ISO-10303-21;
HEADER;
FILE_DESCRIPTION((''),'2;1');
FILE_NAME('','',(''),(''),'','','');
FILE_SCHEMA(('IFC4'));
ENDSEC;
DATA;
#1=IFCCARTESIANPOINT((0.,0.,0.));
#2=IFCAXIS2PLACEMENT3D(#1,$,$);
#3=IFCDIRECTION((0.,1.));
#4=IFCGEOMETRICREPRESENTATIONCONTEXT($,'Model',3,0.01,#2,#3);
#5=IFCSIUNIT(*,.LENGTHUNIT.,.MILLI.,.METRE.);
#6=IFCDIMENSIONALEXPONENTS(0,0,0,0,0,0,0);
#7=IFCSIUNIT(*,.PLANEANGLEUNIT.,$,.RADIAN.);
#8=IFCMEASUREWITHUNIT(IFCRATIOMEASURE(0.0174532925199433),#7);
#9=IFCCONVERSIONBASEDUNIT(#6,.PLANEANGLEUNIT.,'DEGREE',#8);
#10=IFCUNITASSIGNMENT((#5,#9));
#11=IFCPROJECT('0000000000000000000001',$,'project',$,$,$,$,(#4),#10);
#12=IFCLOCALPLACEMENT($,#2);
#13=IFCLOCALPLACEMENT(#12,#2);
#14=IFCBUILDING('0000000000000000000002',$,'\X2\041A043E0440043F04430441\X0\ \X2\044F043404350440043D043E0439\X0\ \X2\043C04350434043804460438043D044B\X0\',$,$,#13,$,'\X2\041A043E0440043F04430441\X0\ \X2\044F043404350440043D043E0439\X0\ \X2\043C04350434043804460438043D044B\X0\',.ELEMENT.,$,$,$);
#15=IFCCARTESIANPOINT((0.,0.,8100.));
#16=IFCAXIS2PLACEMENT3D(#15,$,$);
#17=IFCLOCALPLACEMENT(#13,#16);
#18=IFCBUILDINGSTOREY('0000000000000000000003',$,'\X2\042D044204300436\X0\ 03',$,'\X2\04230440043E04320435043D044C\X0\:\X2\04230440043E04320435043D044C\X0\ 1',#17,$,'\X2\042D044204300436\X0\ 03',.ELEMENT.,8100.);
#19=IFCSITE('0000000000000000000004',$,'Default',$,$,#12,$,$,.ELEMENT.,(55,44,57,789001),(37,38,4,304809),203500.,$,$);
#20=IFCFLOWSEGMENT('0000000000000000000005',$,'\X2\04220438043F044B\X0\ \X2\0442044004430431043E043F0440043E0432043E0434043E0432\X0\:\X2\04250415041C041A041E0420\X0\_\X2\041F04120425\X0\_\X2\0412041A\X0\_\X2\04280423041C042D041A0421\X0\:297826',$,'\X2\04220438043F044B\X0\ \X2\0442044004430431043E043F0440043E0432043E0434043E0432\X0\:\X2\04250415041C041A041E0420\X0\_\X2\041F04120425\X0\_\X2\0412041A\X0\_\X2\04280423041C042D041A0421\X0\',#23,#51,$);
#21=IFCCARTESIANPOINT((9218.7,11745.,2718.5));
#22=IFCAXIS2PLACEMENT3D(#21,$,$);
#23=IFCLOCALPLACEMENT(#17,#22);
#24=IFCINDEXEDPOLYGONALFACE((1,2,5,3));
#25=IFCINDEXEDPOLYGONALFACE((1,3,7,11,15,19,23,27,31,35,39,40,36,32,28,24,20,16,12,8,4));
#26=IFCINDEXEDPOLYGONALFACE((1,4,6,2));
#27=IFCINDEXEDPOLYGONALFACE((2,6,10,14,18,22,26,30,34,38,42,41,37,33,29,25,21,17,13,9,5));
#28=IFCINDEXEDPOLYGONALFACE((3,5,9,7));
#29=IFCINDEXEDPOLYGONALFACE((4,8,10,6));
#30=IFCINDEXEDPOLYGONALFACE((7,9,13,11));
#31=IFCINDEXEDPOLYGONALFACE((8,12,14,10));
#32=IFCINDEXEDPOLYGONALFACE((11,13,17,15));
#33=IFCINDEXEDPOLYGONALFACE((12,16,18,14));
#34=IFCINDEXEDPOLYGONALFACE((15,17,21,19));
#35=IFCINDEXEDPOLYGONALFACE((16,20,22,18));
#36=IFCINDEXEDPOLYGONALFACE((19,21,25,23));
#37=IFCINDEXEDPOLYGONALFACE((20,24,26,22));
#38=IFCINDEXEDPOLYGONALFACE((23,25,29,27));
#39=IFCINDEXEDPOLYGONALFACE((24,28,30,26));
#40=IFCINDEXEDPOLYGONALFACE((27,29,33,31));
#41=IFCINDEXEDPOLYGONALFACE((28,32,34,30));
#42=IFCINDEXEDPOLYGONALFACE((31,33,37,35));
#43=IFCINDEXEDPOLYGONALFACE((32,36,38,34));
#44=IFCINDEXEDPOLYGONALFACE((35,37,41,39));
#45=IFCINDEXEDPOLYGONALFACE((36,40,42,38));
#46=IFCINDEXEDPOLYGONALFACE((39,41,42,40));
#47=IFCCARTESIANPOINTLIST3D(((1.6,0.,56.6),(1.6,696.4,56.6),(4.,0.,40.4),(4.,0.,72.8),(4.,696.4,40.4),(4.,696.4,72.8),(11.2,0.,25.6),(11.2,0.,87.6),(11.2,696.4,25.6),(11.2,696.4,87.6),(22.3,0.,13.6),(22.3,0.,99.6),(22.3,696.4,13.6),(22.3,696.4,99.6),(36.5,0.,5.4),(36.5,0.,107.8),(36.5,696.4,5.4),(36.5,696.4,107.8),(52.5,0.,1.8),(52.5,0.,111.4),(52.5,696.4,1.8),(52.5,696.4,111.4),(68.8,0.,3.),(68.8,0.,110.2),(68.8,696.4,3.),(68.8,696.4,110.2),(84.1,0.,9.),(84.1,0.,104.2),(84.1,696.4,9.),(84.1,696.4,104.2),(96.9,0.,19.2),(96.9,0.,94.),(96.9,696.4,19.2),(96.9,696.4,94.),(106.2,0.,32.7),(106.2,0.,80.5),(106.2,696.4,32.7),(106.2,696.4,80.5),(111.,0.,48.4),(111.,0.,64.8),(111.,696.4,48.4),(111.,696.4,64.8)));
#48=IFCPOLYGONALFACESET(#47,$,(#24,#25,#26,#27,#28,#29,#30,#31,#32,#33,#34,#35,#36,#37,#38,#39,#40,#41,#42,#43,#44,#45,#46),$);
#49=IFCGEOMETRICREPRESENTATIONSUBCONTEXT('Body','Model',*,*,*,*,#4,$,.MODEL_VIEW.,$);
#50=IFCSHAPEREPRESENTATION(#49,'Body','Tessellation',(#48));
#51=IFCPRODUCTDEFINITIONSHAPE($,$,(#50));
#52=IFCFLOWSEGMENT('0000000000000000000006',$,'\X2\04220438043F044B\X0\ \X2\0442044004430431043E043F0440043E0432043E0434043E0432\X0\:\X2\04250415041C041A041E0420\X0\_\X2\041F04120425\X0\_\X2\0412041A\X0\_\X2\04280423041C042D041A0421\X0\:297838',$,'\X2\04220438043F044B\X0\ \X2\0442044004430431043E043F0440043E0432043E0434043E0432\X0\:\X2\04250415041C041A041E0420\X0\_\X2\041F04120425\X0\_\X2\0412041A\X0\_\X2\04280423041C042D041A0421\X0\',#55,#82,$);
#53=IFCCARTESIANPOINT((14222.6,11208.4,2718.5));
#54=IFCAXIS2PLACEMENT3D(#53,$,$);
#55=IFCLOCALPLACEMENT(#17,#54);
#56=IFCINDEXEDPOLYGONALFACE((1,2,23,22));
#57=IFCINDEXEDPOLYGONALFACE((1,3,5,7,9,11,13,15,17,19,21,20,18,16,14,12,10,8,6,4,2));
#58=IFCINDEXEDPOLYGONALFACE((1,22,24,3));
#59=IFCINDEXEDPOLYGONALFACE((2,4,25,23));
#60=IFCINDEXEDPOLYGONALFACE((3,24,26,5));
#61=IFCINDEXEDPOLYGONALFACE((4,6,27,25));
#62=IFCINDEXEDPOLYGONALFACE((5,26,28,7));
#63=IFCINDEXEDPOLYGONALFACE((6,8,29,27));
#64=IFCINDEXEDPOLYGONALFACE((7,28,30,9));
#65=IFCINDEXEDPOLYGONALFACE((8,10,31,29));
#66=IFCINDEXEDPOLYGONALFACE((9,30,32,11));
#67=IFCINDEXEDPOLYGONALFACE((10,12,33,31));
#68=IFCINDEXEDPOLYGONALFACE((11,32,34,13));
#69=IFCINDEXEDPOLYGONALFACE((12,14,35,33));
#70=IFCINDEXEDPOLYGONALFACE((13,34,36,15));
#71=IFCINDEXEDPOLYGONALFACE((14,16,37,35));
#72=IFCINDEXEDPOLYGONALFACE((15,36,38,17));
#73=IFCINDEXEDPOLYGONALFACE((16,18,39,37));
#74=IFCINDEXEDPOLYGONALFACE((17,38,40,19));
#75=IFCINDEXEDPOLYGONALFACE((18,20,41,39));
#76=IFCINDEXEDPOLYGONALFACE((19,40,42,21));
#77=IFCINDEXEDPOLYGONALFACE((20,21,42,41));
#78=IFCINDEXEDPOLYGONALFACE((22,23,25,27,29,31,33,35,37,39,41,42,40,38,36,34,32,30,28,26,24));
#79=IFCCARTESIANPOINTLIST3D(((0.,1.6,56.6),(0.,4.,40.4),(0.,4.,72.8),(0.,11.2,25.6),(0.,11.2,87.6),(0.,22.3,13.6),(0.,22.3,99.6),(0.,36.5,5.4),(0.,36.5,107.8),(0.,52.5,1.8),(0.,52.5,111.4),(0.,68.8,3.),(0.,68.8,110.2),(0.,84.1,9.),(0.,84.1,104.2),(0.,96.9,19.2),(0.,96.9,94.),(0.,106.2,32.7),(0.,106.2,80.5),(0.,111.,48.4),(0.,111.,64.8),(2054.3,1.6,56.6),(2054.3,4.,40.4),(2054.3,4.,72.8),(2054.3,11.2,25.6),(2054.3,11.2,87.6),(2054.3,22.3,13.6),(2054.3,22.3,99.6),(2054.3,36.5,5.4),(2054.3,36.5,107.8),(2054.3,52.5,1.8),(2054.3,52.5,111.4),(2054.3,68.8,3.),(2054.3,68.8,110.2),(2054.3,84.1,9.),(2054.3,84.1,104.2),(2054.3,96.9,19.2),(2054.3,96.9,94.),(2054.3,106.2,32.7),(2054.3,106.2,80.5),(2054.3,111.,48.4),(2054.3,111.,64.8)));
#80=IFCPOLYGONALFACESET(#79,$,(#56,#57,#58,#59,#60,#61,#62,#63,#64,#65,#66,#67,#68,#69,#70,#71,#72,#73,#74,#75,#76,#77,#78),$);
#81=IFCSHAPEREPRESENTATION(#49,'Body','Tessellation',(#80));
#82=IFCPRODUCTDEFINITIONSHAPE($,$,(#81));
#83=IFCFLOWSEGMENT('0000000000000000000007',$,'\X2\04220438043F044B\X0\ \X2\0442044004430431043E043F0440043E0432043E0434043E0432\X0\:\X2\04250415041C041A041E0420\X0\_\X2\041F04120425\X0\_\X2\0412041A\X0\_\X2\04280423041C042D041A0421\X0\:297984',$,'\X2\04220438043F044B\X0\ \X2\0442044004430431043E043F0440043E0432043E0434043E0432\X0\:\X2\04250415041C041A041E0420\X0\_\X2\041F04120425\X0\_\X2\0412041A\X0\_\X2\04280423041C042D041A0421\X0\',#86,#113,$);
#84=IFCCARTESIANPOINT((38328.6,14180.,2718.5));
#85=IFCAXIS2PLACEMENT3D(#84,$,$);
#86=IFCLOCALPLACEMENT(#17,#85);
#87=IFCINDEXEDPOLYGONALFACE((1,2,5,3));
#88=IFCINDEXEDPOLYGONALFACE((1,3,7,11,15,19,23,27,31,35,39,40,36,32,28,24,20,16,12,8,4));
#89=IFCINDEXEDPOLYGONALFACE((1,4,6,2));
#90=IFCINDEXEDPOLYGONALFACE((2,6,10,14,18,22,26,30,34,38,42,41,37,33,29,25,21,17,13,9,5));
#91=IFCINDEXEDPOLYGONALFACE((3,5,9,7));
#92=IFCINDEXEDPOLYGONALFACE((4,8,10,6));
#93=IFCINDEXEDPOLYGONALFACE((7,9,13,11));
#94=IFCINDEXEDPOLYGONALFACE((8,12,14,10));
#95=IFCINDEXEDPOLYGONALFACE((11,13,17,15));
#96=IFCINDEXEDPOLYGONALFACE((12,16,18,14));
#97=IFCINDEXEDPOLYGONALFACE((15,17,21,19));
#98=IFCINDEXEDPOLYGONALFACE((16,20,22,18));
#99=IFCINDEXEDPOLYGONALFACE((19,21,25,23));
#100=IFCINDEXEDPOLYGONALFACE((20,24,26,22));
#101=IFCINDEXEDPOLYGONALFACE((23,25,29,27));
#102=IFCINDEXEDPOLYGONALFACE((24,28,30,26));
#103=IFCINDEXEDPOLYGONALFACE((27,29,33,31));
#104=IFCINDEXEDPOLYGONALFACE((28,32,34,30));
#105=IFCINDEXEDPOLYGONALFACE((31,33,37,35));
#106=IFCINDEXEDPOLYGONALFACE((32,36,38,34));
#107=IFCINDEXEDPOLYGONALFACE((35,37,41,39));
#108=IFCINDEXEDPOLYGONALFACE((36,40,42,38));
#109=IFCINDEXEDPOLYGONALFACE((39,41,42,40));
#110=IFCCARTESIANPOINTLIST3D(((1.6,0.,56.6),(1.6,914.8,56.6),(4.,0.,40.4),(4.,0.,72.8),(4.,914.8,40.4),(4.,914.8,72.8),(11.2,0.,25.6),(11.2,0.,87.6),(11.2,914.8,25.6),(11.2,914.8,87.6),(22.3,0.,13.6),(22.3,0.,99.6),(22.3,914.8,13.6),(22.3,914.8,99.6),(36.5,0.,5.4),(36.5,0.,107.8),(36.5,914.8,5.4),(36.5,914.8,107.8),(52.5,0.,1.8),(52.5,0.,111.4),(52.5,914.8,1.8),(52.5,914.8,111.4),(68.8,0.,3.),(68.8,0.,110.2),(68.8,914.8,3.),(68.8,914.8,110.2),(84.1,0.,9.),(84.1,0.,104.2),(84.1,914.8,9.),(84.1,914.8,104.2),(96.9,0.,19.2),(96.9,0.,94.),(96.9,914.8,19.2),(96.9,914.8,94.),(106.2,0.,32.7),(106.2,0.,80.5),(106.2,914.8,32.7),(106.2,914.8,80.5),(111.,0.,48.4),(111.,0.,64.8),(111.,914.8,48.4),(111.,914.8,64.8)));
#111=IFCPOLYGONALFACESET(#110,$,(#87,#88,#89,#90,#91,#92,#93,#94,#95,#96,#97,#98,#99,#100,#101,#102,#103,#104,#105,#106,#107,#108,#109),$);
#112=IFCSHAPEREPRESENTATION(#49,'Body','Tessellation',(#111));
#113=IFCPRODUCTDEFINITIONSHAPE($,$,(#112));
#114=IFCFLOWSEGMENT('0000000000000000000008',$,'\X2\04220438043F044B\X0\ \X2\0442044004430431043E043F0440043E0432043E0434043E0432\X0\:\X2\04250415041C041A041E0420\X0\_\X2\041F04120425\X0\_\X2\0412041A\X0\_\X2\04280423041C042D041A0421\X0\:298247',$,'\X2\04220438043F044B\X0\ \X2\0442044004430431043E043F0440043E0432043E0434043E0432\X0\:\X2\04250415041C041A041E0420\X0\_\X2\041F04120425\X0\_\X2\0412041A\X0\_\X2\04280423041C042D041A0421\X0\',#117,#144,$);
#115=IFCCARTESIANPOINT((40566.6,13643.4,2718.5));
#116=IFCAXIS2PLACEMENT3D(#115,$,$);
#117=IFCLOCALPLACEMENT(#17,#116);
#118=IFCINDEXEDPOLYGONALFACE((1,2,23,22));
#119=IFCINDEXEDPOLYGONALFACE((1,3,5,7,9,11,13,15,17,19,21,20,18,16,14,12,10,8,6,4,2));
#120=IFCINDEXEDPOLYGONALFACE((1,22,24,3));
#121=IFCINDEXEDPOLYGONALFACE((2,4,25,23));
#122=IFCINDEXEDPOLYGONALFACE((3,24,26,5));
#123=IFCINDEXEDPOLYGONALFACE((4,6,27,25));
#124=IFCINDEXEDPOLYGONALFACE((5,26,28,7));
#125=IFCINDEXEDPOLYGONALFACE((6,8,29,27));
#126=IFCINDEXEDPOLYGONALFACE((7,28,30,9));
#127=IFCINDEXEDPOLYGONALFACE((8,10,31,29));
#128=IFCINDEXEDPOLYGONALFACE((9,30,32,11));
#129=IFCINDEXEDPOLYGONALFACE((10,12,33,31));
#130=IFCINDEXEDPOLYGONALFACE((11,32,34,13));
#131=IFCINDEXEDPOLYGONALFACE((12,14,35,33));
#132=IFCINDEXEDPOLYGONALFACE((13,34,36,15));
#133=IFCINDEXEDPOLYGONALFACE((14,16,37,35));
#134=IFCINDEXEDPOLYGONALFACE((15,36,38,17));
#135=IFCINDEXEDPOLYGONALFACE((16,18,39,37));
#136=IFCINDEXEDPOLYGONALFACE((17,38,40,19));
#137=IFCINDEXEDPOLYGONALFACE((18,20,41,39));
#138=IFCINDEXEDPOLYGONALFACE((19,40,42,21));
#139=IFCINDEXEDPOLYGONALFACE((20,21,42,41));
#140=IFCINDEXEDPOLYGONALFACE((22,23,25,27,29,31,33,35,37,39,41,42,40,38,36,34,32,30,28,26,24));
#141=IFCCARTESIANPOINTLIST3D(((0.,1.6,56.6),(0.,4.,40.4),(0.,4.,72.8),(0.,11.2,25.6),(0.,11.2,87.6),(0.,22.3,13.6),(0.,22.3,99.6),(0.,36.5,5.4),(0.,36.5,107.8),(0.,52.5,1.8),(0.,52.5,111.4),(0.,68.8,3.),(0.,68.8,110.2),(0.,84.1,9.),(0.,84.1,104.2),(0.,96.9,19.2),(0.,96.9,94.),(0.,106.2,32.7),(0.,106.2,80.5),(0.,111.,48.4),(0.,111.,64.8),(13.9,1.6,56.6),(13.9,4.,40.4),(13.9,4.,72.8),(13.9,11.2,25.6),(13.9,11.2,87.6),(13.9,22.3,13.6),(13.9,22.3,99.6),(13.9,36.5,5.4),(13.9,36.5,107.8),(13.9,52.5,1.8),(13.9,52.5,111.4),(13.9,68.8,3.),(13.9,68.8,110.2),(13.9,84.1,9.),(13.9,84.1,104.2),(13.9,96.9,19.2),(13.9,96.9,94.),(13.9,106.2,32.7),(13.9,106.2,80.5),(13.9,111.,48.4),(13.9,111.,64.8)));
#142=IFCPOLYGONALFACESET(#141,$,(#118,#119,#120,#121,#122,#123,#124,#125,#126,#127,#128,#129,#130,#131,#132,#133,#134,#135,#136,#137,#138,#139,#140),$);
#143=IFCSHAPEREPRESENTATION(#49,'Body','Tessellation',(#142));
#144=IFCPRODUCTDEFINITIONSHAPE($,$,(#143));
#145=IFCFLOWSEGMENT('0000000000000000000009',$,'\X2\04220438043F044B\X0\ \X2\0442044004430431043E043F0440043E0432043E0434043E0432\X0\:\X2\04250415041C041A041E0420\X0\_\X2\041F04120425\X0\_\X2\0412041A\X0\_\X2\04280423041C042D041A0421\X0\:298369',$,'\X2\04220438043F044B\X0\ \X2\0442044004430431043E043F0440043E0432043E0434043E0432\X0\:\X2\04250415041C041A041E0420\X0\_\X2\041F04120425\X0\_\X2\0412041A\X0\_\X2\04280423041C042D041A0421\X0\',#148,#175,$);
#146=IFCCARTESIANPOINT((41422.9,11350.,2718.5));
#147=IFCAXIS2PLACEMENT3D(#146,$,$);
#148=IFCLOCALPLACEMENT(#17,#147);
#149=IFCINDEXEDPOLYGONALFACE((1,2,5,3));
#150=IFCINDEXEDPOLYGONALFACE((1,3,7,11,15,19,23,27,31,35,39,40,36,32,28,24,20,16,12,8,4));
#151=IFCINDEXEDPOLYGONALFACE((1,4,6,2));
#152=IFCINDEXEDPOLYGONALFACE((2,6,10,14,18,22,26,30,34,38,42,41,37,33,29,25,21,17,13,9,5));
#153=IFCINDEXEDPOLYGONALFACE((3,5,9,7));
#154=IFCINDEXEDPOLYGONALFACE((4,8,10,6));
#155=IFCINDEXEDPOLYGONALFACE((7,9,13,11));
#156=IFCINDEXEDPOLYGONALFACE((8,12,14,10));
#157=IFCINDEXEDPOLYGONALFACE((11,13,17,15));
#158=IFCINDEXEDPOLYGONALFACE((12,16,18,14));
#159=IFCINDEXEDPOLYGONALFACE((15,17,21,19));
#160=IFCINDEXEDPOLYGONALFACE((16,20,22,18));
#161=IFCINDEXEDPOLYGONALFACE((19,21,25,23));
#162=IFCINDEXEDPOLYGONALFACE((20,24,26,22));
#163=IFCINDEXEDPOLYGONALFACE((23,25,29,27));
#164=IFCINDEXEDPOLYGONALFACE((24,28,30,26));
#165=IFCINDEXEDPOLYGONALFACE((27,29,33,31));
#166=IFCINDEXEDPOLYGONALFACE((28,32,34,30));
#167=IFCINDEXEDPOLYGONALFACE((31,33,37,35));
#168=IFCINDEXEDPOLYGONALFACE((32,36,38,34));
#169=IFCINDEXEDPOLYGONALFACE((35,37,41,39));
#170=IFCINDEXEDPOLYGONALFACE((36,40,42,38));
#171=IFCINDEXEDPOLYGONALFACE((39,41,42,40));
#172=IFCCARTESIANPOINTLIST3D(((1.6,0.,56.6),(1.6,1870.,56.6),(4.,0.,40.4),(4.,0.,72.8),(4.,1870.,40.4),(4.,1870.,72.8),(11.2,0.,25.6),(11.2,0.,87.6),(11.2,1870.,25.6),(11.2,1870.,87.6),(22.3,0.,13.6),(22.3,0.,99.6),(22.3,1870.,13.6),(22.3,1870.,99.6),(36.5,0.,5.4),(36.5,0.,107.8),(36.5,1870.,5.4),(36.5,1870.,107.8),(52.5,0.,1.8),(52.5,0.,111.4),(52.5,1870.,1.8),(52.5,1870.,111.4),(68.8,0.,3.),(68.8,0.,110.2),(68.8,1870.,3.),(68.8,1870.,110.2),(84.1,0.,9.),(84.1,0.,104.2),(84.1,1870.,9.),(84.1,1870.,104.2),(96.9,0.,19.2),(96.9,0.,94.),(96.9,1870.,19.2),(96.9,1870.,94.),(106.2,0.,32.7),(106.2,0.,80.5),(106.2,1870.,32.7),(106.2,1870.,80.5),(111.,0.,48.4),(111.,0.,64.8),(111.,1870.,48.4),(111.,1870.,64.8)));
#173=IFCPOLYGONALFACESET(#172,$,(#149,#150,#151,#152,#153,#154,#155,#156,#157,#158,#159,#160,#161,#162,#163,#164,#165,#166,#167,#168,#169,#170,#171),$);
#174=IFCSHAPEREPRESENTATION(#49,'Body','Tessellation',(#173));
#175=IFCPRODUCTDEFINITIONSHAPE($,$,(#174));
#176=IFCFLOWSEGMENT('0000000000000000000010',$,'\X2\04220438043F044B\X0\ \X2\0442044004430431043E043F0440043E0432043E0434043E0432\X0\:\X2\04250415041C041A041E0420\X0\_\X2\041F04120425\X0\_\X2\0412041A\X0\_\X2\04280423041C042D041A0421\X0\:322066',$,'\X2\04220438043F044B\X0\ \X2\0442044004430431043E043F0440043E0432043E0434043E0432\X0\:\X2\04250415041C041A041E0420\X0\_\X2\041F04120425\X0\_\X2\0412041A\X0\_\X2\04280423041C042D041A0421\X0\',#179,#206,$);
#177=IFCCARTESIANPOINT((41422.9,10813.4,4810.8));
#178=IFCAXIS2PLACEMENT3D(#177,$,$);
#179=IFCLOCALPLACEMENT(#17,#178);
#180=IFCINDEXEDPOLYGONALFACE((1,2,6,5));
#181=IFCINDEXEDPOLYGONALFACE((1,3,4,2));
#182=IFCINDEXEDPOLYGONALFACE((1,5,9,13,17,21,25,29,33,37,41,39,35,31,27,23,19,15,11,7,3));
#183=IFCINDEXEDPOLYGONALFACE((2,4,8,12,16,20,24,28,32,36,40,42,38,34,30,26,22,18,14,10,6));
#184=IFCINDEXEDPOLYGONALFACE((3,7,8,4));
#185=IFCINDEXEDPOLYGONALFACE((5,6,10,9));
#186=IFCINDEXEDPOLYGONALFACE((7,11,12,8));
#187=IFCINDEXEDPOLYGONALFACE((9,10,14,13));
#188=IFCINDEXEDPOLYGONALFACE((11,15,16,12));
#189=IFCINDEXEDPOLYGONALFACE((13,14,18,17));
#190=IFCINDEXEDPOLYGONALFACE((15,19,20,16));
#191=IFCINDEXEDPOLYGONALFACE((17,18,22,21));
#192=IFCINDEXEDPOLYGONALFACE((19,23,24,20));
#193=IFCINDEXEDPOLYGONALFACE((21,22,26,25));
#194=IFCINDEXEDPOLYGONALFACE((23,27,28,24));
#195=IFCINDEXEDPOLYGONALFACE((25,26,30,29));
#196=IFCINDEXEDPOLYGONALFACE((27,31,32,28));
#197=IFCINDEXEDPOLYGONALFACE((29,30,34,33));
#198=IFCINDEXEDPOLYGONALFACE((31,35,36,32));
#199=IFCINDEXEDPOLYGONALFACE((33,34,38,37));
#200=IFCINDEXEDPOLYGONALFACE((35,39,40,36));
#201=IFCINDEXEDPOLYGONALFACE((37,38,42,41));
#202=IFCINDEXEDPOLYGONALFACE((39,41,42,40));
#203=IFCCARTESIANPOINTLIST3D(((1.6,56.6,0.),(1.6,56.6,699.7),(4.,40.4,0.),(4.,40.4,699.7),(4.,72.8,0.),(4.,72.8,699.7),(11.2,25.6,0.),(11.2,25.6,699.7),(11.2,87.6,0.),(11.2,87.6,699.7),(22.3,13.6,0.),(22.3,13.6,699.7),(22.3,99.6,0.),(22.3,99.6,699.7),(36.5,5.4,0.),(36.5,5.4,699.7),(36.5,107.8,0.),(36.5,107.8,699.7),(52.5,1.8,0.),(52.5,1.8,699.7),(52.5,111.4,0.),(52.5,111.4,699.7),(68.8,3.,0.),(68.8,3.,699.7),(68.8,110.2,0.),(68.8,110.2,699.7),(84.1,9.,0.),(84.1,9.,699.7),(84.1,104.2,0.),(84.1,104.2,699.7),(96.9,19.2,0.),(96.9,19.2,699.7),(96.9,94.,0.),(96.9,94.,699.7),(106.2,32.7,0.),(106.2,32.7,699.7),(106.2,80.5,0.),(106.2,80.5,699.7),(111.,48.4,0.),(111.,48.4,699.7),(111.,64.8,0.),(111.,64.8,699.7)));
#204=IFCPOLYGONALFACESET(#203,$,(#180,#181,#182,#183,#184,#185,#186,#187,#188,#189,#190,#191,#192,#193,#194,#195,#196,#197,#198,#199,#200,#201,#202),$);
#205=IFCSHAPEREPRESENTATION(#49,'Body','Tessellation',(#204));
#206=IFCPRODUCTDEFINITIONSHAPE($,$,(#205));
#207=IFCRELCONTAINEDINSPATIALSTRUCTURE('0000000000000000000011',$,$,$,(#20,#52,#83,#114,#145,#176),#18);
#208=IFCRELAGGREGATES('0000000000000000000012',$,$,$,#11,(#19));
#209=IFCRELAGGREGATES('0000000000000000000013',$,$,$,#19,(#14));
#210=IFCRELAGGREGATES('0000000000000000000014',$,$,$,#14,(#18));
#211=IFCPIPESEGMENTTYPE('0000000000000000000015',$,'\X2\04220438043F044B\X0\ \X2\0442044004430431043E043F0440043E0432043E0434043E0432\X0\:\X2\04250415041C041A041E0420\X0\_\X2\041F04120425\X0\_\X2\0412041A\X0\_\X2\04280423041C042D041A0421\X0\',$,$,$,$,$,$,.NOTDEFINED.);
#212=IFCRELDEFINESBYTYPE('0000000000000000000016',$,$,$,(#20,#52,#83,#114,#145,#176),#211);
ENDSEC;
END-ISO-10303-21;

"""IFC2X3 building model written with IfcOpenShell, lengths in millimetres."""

from ifc_helpers import new_model, entity, si_unit, converted_unit, direction, frame, origin, origin_2d_with_axis, place, context, subcontext, project, spatial, circle, extrude, type_object, element, save


model = new_model("IFC2X3")

# Units and contexts
model_context = context("Model", 3, precision=0.01, world=origin(), true_north=direction((0.0, 1.0)))
body_context = subcontext(model_context, "Body", "Model", "MODEL_VIEW")
ifc_project = project(units=[si_unit("LENGTHUNIT", "METRE", prefix="MILLI"), converted_unit("PLANEANGLEUNIT", "DEGREE", entity("IfcRatioMeasure", 0.0174532925199433), si_unit("PLANEANGLEUNIT", "RADIAN"), dimensions=[0, 0, 0, 0, 0, 0, 0])], contexts=[model_context])

# Site, building, storey
site_placement = place(None, origin())
site = spatial("IfcSite", under=ifc_project, at=site_placement, Name="Default", CompositionType="ELEMENT", RefLatitude=(55, 44, 57, 789001), RefLongitude=(37, 38, 4, 304809), RefElevation=203500.0)
building_placement = place(site_placement, origin())
building = spatial("IfcBuilding", under=site, at=building_placement, Name="Корпус ядерной медицины", LongName="Корпус ядерной медицины", CompositionType="ELEMENT")
storey_placement = place(building_placement, frame((0.0, 0.0, 8100.0)))
storey = spatial("IfcBuildingStorey", under=building, at=storey_placement, Name="Этаж 03", ObjectType="Уровень:Уровень 1", LongName="Этаж 03", CompositionType="ELEMENT", Elevation=8100.0)

# Flow segments
pipe_segment_type = type_object("IfcPipeSegmentType", Name="Типы трубопроводов:ХЕМКОР_ПВХ_ВК_ШУМЭКС", PredefinedType="NOTDEFINED")
flow_segment_1_placement = place(storey_placement, frame((9218.7, 11745.0, 2718.5)))
element("IfcFlowSegment", 1, at=flow_segment_1_placement, inside=storey, type_object=pipe_segment_type, Name="Типы трубопроводов:ХЕМКОР_ПВХ_ВК_ШУМЭКС:297826", ObjectType="Типы трубопроводов:ХЕМКОР_ПВХ_ВК_ШУМЭКС", context=body_context, shape_type="SweptSolid", body=[
    extrude(circle(Radius=55.0, at=origin_2d_with_axis()), frame((56.6, 0.0, 56.6), z_axis=(0.0, 1.0, 0.0), x_axis=(-1.0, 0.0, 0.0)), (0.0, 0.0, 1.0), 696.4),
])
flow_segment_2_placement = place(storey_placement, frame((14222.6, 11208.4, 2718.5)))
element("IfcFlowSegment", 2, at=flow_segment_2_placement, inside=storey, type_object=pipe_segment_type, Name="Типы трубопроводов:ХЕМКОР_ПВХ_ВК_ШУМЭКС:297838", ObjectType="Типы трубопроводов:ХЕМКОР_ПВХ_ВК_ШУМЭКС", context=body_context, shape_type="SweptSolid", body=[
    extrude(circle(Radius=55.0, at=origin_2d_with_axis()), frame((0.0, 56.6, 56.6), z_axis=(1.0, 0.0, 0.0), x_axis=(0.0, -1.0, 0.0)), (0.0, 0.0, 1.0), 2054.3),
])
flow_segment_3_placement = place(storey_placement, frame((38328.6, 14180.0, 2718.5)))
element("IfcFlowSegment", 3, at=flow_segment_3_placement, inside=storey, type_object=pipe_segment_type, Name="Типы трубопроводов:ХЕМКОР_ПВХ_ВК_ШУМЭКС:297984", ObjectType="Типы трубопроводов:ХЕМКОР_ПВХ_ВК_ШУМЭКС", context=body_context, shape_type="SweptSolid", body=[
    extrude(circle(Radius=55.0, at=origin_2d_with_axis()), frame((56.6, 0.0, 56.6), z_axis=(0.0, 1.0, 0.0), x_axis=(-1.0, 0.0, 0.0)), (0.0, 0.0, 1.0), 914.8),
])
flow_segment_4_placement = place(storey_placement, frame((40566.6, 13643.4, 2718.5)))
element("IfcFlowSegment", 4, at=flow_segment_4_placement, inside=storey, type_object=pipe_segment_type, Name="Типы трубопроводов:ХЕМКОР_ПВХ_ВК_ШУМЭКС:298247", ObjectType="Типы трубопроводов:ХЕМКОР_ПВХ_ВК_ШУМЭКС", context=body_context, shape_type="SweptSolid", body=[
    extrude(circle(Radius=55.0, at=origin_2d_with_axis()), frame((0.0, 56.6, 56.6), z_axis=(1.0, 0.0, 0.0), x_axis=(0.0, -1.0, 0.0)), (0.0, 0.0, 1.0), 13.9),
])
flow_segment_5_placement = place(storey_placement, frame((41422.9, 11350.0, 2718.5)))
element("IfcFlowSegment", 5, at=flow_segment_5_placement, inside=storey, type_object=pipe_segment_type, Name="Типы трубопроводов:ХЕМКОР_ПВХ_ВК_ШУМЭКС:298369", ObjectType="Типы трубопроводов:ХЕМКОР_ПВХ_ВК_ШУМЭКС", context=body_context, shape_type="SweptSolid", body=[
    extrude(circle(Radius=55.0, at=origin_2d_with_axis()), frame((56.6, 0.0, 56.6), z_axis=(0.0, 1.0, 0.0), x_axis=(-1.0, 0.0, 0.0)), (0.0, 0.0, 1.0), 1870.0),
])
flow_segment_6_placement = place(storey_placement, frame((41422.9, 10813.4, 4810.8)))
element("IfcFlowSegment", 6, at=flow_segment_6_placement, inside=storey, type_object=pipe_segment_type, Name="Типы трубопроводов:ХЕМКОР_ПВХ_ВК_ШУМЭКС:322066", ObjectType="Типы трубопроводов:ХЕМКОР_ПВХ_ВК_ШУМЭКС", context=body_context, shape_type="SweptSolid", body=[
    extrude(circle(Radius=55.0, at=origin_2d_with_axis()), frame((56.6, 56.6, 0.0), z_axis=(0.0, 0.0, 1.0), x_axis=(-1.0, 0.0, 0.0)), (0.0, 0.0, 1.0), 699.7),
])

save(model, "model.ifc")
